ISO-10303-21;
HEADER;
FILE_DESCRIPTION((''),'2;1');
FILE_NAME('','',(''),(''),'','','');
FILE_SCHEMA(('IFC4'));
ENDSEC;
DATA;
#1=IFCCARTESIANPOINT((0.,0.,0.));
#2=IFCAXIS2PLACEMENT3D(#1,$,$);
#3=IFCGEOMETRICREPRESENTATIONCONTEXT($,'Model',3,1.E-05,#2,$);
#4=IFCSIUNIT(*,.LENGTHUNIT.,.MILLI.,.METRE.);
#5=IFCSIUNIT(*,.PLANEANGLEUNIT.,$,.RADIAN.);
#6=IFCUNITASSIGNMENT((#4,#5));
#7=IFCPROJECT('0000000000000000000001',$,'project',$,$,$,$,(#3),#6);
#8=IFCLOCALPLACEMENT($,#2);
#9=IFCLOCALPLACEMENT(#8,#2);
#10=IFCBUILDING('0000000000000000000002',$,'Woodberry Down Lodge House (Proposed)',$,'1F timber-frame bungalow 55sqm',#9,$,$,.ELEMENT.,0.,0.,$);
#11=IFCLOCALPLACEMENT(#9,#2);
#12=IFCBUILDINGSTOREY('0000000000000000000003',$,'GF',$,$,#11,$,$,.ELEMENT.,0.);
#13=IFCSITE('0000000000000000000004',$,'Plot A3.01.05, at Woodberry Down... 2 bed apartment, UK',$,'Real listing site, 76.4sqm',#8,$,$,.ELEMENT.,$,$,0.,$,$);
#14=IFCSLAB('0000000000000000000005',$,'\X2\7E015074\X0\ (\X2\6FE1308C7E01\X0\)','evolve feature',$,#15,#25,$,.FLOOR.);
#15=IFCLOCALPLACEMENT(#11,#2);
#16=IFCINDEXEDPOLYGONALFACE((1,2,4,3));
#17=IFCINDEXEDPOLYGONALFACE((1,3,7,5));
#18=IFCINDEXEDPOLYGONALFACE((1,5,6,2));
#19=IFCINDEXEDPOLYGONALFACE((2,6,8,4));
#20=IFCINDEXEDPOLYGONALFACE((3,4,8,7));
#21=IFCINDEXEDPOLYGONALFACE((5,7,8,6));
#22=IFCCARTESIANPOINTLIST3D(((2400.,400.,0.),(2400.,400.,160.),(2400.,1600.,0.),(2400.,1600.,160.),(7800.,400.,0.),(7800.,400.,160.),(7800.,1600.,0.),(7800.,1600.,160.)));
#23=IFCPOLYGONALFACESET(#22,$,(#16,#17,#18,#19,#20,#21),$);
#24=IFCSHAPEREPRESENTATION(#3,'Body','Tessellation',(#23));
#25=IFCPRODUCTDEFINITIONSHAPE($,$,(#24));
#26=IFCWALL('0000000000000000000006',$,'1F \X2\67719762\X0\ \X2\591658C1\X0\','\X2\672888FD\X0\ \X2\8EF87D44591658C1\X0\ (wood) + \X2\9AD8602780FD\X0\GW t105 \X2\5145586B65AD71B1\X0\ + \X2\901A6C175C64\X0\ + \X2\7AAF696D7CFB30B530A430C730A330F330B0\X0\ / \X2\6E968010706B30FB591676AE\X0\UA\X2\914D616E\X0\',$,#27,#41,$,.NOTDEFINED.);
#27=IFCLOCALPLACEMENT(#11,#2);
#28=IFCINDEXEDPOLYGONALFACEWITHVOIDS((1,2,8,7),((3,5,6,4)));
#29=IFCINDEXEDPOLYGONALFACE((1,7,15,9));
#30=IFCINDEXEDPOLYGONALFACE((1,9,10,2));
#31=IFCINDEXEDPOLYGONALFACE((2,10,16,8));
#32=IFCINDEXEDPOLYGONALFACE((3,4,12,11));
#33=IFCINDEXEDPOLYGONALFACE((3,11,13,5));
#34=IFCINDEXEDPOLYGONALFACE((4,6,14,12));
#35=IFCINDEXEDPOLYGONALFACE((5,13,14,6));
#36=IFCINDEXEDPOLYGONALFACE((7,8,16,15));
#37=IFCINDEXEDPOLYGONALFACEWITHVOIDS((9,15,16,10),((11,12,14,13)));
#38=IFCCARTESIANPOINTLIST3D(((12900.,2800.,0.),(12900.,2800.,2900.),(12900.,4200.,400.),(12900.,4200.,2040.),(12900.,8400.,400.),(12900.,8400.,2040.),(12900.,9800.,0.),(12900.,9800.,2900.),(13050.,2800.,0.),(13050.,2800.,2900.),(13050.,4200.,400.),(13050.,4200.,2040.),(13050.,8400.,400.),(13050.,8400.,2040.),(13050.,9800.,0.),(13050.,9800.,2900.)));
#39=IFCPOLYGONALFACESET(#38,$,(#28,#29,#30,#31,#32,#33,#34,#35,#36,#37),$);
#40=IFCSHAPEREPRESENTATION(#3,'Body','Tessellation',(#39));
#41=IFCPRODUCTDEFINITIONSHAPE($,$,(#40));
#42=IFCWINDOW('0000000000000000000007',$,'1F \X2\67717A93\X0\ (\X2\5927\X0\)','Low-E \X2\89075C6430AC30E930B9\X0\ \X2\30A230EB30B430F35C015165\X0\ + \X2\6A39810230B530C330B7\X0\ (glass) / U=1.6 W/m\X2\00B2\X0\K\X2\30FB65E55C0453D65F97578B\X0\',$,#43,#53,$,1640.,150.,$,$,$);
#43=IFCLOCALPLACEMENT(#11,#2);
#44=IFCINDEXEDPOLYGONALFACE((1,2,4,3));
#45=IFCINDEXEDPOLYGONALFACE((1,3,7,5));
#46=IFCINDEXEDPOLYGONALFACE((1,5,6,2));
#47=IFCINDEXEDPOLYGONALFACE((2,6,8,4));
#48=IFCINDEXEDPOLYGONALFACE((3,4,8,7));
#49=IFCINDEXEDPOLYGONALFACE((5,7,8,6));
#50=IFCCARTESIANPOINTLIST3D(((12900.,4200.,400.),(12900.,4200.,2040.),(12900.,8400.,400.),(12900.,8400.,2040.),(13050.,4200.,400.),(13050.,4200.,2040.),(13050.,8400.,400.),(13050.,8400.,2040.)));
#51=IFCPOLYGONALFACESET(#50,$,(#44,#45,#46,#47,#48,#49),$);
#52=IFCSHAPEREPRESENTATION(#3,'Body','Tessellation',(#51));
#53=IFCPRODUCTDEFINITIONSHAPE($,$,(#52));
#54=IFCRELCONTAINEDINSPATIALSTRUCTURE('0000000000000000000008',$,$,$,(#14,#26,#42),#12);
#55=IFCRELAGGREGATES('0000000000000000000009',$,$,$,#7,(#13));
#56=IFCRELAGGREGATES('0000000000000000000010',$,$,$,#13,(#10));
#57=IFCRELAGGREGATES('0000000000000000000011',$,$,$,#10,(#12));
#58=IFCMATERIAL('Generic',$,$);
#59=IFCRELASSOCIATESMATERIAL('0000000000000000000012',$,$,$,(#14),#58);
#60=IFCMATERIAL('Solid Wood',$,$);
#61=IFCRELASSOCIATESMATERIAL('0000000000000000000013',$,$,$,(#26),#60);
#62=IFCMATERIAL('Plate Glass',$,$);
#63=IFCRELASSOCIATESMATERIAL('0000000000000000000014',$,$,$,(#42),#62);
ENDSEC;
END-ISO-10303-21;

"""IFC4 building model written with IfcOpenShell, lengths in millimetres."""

from ifc_helpers import new_model, si_unit, frame, frame_2d, origin, place, context, project, spatial, rectangle, extrude, material, element, fill, save


model = new_model("IFC4")

# Units and contexts
model_context = context("Model", 3, precision=1e-05, world=origin())
ifc_project = project(units=[si_unit("LENGTHUNIT", "METRE", prefix="MILLI"), si_unit("PLANEANGLEUNIT", "RADIAN")], contexts=[model_context])

# Site, building, storey
site_placement = place(None, origin())
site = spatial("IfcSite", under=ifc_project, at=site_placement, Name="Plot A3.01.05, at Woodberry Down... 2 bed apartment, UK", ObjectType="Real listing site, 76.4sqm", CompositionType="ELEMENT", RefElevation=0.0)
building_placement = place(site_placement, origin())
building = spatial("IfcBuilding", under=site, at=building_placement, Name="Woodberry Down Lodge House (Proposed)", ObjectType="1F timber-frame bungalow 55sqm", CompositionType="ELEMENT", ElevationOfRefHeight=0.0, ElevationOfTerrain=0.0)
storey_placement = place(building_placement, origin())
storey = spatial("IfcBuildingStorey", under=building, at=storey_placement, Name="GF", CompositionType="ELEMENT", Elevation=0.0)

# Slab
ifc_material_1 = material(Name="Solid Wood")
ifc_material_2 = material(Name="Generic")
slab_1_placement = place(storey_placement, frame((1200.0, 200.0, 0.0)))
element("IfcSlab", 1, at=slab_1_placement, inside=storey, material=ifc_material_2, Name="縁側 (濡れ縁)", Description="evolve feature", PredefinedType="FLOOR", context=model_context, shape_type="SweptSolid", body=[
    extrude(rectangle(XDim=5400.0, YDim=1200.0, at=frame_2d((2700.0, 600.0))), frame((1200.0, 200.0, 0.0)), (0.0, 0.0, 1.0), 160.0),
])

# Shared definitions
ifc_material_3 = material(Name="Plate Glass")

# Wall, opening, window
wall_1_placement = place(storey_placement, frame((6450.0, 1400.0, 0.0)))
wall_1 = element("IfcWall", 2, at=wall_1_placement, inside=storey, material=ifc_material_1, Name="1F 東面 外壁", Description="木製 軸組外壁 (wood) + 高性能GW t105 充填断熱 + 通気層 + 窯業系サイディング / 準耐火・外皮UA配慮", PredefinedType="NOTDEFINED", context=model_context, shape_type="SweptSolid", body=[
    extrude(rectangle(XDim=150.0, YDim=7000.0, at=frame_2d((75.0, 3500.0))), frame((6450.0, 1400.0, 0.0)), (0.0, 0.0, 1.0), 2900.0),
])
opening_1_placement = place(storey_placement, frame((6450.0, 2100.0, 200.0)))
opening_1 = element("IfcOpeningElement", 3, at=opening_1_placement, cuts=wall_1, PredefinedType="NOTDEFINED", context=model_context, shape_type="SweptSolid", body=[
    extrude(rectangle(XDim=150.0, YDim=4200.0, at=frame_2d((75.0, 2100.0))), frame((6450.0, 2100.0, 200.0)), (0.0, 0.0, 1.0), 1640.0),
])
window_1_placement = place(storey_placement, frame((6450.0, 2100.0, 200.0)))
window_1 = element("IfcWindow", 4, at=window_1_placement, inside=storey, material=ifc_material_3, Name="1F 東窓 (大)", Description="Low-E 複層ガラス アルゴン封入 + 樹脂サッシ (glass) / U=1.6 W/m²K・日射取得型", OverallHeight=1640.0, OverallWidth=150.0, context=model_context, shape_type="SweptSolid", body=[
    extrude(rectangle(XDim=150.0, YDim=4200.0, at=frame_2d((75.0, 2100.0))), frame((6450.0, 2100.0, 200.0)), (0.0, 0.0, 1.0), 1640.0),
])
fill(opening_1, window_1)

save(model, "model.ifc")
